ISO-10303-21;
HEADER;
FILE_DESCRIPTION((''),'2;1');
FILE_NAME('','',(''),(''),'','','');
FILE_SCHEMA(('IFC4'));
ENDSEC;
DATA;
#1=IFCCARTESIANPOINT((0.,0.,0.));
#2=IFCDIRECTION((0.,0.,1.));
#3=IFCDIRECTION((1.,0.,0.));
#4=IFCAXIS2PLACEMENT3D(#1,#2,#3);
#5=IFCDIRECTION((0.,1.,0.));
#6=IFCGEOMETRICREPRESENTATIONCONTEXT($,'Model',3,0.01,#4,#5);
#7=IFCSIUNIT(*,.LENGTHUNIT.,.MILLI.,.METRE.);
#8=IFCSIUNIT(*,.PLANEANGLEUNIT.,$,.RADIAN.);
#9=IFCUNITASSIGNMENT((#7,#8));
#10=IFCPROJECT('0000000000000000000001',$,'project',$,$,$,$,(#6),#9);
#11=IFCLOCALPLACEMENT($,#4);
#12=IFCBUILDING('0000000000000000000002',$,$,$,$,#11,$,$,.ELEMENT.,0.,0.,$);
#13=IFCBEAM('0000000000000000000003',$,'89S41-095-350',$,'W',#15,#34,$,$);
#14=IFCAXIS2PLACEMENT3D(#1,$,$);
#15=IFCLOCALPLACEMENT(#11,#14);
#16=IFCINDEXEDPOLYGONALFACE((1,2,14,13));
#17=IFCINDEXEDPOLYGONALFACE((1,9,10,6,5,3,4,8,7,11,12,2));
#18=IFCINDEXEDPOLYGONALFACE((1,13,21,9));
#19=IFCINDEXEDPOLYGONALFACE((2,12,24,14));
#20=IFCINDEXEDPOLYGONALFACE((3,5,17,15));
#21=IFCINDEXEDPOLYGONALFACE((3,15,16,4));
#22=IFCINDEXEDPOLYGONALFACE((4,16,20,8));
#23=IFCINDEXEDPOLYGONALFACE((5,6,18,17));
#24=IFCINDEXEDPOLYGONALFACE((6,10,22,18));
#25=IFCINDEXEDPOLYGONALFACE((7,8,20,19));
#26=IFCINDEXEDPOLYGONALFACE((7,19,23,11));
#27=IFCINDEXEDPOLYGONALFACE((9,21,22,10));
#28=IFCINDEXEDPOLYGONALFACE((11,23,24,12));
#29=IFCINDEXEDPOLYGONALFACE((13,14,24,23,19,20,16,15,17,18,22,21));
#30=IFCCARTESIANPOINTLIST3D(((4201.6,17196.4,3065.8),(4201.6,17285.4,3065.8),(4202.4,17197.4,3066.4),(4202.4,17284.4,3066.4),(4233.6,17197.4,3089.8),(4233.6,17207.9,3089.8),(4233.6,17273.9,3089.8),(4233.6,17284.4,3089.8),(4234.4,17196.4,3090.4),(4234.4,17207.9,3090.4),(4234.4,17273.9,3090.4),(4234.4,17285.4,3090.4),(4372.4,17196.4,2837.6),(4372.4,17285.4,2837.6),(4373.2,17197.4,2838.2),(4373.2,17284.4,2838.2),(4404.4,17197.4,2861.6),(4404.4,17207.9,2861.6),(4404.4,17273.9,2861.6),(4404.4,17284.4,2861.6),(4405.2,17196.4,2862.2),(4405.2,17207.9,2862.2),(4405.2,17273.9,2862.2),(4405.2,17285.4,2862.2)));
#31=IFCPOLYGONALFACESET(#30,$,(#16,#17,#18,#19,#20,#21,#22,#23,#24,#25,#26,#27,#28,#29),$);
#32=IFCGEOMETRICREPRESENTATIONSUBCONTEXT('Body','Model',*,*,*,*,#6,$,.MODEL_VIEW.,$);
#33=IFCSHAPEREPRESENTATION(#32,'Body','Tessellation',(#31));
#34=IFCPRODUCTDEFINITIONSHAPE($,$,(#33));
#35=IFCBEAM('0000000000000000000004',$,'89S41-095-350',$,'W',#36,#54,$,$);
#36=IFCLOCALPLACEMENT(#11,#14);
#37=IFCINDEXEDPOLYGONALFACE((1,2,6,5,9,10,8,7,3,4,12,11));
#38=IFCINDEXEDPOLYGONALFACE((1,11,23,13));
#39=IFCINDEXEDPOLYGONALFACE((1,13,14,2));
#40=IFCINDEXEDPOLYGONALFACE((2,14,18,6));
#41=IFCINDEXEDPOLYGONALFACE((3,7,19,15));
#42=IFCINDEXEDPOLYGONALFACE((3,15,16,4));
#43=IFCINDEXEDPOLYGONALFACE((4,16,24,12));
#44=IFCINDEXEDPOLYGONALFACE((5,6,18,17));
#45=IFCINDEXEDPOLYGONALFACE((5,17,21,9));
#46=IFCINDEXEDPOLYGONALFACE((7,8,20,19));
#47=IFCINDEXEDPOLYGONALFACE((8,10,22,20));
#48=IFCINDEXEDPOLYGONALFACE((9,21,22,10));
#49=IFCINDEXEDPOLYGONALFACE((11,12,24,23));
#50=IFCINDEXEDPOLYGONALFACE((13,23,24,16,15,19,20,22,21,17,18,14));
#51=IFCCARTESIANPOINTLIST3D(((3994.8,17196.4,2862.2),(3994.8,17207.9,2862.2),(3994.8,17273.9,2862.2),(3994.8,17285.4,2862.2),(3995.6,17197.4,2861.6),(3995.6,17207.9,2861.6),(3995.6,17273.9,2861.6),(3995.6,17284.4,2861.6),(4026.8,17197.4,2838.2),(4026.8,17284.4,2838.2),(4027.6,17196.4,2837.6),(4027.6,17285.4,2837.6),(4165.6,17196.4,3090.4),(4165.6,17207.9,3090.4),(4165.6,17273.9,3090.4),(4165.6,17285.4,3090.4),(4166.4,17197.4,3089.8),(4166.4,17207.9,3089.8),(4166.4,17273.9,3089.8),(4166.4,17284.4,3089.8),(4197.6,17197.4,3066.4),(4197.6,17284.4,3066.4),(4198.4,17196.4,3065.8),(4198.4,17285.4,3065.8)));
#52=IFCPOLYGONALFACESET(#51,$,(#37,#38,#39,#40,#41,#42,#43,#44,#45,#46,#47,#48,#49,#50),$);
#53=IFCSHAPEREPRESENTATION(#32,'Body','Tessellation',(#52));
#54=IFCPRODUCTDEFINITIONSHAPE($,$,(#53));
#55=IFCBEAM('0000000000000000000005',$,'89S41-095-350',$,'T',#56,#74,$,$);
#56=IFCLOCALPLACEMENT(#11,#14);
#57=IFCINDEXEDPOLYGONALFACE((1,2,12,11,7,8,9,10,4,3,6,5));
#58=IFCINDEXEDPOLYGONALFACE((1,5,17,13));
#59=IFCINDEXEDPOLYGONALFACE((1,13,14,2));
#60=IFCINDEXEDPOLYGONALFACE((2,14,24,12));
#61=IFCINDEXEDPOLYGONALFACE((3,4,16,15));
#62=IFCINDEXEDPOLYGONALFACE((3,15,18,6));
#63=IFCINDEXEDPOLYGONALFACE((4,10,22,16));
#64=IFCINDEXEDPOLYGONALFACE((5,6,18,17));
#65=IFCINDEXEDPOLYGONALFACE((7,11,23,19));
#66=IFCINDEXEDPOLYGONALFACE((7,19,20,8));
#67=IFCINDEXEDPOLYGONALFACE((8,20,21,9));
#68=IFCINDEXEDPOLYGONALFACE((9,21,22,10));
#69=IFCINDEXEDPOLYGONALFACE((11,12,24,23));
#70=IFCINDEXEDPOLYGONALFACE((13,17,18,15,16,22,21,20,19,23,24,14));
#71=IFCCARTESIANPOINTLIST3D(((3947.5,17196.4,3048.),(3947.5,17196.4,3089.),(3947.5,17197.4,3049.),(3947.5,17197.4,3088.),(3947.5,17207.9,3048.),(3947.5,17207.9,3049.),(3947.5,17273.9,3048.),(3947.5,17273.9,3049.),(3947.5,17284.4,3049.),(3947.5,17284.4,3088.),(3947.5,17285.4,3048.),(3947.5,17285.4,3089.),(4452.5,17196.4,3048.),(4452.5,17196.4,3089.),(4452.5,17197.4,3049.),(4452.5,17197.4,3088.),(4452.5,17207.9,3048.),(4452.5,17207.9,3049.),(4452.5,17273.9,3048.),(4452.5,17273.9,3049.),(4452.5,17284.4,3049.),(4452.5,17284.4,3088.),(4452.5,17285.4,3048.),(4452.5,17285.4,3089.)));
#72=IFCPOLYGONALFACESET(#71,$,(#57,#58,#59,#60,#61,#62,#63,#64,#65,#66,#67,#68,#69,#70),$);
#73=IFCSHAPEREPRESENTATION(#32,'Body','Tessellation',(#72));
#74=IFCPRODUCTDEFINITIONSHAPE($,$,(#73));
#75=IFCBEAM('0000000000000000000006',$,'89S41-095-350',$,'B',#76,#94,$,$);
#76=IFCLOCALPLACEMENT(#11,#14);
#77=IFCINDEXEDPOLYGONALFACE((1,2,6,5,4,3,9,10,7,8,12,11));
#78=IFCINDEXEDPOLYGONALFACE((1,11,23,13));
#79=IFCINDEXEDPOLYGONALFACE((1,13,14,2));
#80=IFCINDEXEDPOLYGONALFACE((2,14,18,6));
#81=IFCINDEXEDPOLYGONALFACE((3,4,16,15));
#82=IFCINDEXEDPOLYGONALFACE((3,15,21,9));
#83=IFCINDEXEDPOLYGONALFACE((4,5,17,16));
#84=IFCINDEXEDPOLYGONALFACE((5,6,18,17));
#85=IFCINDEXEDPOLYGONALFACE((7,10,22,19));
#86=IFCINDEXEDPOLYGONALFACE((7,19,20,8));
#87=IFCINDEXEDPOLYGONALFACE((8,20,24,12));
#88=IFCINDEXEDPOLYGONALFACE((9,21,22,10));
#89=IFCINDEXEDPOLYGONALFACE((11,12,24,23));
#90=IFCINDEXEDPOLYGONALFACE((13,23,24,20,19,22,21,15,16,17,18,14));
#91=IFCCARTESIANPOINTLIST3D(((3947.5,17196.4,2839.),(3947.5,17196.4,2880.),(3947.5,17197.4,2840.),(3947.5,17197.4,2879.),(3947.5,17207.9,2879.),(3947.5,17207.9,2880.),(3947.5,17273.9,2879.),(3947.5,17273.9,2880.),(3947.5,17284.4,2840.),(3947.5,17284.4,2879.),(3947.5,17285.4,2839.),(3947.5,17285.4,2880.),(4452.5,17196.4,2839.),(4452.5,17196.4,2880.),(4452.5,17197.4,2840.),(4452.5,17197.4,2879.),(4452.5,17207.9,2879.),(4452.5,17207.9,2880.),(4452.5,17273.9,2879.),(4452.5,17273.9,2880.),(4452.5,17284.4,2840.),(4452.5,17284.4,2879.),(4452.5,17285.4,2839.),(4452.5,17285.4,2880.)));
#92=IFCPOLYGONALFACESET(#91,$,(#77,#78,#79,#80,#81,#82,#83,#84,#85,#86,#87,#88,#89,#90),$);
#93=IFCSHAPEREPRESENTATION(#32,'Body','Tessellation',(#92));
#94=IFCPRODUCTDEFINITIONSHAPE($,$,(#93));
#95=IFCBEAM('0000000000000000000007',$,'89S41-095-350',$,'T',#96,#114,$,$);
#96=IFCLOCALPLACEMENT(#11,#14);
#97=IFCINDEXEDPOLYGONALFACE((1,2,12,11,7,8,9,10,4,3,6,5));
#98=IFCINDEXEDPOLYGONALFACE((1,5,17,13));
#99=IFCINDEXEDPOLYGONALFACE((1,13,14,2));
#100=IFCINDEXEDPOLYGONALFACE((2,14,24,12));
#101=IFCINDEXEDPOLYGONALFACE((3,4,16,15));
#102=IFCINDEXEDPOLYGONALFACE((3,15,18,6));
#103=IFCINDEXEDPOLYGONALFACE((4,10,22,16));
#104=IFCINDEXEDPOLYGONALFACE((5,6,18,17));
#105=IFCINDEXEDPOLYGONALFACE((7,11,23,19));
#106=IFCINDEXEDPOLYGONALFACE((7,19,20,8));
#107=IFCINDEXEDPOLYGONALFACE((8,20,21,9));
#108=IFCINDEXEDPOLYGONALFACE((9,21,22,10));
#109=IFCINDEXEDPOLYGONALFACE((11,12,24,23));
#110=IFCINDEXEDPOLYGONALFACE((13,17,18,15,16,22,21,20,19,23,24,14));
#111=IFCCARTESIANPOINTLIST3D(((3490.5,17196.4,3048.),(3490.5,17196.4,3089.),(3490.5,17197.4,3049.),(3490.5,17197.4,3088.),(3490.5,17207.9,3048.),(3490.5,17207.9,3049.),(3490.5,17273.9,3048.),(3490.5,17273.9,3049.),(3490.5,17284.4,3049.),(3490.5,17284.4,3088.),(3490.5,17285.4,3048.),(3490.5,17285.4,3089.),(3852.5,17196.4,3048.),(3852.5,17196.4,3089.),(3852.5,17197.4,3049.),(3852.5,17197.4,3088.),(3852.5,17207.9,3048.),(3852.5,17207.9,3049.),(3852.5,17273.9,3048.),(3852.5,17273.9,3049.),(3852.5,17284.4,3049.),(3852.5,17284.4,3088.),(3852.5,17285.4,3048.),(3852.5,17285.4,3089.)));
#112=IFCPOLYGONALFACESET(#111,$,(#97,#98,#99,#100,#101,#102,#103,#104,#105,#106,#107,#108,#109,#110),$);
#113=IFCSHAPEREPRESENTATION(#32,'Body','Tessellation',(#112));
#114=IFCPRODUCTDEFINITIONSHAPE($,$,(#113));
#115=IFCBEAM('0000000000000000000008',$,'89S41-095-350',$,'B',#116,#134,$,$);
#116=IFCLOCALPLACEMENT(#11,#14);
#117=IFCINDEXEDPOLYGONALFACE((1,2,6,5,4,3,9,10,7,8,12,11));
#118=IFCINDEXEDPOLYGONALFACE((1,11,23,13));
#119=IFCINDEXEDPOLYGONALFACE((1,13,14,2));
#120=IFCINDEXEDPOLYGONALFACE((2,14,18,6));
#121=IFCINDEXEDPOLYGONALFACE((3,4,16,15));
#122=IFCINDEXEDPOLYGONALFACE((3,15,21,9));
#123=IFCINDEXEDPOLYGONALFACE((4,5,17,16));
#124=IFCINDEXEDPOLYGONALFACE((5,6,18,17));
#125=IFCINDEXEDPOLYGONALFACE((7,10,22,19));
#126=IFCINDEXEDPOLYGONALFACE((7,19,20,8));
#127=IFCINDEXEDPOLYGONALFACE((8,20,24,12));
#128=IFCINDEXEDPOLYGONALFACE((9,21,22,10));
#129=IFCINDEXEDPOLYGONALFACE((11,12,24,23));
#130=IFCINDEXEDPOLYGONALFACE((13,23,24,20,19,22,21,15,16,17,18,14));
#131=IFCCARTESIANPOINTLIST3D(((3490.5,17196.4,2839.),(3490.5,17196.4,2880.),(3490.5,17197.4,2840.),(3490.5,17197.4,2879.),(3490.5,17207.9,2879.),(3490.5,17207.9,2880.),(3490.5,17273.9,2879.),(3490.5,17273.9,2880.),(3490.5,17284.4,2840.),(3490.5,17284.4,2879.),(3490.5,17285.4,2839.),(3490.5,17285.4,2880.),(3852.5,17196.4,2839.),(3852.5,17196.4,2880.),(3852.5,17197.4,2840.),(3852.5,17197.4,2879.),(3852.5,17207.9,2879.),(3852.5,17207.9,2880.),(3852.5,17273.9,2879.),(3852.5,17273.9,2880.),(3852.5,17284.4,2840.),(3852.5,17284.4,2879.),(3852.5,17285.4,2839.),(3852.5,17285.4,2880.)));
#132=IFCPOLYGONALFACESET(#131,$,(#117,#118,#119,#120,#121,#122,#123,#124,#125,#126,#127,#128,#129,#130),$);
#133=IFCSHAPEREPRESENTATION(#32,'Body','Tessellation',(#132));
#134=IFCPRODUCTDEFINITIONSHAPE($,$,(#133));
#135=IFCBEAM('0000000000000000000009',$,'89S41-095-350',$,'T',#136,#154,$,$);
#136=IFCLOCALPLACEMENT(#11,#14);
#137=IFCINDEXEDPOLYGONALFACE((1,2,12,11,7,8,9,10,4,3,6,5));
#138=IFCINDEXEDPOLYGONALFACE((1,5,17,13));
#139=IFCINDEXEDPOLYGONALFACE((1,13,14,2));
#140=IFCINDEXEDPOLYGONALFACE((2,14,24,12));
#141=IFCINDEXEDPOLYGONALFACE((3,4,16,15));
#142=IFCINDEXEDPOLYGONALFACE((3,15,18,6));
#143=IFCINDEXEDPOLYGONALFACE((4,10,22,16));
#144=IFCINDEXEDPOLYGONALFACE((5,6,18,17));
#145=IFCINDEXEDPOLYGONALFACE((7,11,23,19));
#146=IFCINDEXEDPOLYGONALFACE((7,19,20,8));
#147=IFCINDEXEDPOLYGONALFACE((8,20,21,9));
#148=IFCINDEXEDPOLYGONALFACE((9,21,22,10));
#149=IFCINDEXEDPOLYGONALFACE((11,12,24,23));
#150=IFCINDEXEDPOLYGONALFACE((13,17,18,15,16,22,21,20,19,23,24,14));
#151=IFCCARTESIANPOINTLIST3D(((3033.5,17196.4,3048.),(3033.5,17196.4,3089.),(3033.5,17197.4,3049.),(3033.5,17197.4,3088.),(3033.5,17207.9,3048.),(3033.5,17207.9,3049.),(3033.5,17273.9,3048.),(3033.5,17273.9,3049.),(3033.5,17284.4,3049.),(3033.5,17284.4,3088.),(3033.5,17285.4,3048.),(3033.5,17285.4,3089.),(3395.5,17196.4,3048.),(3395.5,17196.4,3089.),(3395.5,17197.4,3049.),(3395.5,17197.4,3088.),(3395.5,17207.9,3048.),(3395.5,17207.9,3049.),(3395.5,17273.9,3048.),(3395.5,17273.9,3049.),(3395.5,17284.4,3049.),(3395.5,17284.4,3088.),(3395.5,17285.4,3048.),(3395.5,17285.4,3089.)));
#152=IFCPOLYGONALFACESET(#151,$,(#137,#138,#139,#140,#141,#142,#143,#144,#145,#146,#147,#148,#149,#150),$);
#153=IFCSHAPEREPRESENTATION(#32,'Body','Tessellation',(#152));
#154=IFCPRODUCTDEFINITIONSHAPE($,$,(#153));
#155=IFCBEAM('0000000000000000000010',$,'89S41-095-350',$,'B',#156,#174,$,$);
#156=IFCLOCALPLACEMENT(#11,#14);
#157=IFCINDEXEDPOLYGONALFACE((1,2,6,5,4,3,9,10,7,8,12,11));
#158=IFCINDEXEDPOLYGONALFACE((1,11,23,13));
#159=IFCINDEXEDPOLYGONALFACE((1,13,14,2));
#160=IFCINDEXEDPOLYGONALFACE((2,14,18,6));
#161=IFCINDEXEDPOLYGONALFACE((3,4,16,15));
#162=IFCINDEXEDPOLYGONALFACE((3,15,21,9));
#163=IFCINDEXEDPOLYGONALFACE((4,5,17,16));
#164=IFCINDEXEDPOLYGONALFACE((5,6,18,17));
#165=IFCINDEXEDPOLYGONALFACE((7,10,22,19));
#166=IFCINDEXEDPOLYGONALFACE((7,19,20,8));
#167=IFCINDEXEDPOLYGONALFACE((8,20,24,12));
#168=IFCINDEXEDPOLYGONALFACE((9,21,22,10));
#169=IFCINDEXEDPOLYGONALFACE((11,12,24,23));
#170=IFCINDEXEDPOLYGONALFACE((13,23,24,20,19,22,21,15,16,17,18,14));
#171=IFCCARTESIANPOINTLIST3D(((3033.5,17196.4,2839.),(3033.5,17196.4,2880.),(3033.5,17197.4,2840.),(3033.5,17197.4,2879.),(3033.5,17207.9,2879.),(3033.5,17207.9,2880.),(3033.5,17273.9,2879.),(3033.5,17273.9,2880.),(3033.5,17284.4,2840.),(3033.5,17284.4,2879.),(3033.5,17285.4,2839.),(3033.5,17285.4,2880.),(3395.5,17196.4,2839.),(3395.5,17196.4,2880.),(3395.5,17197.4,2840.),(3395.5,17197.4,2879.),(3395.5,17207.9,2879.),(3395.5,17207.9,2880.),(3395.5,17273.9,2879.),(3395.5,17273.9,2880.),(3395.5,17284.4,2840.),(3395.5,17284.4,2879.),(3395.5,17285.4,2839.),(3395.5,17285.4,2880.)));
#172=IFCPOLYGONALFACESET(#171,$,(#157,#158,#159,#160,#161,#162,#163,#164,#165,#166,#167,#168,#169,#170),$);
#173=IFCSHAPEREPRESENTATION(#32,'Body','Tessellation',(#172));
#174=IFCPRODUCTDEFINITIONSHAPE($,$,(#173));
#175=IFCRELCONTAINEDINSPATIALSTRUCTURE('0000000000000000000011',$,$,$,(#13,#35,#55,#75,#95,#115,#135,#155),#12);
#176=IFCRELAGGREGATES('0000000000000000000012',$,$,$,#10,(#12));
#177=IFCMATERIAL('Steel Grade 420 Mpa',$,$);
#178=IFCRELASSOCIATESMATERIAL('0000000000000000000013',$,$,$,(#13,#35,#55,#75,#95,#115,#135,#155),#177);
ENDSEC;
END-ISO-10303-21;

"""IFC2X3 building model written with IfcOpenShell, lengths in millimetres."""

from ifc_helpers import new_model, si_unit, direction, frame, origin, origin_with_axes, origin_2d_with_axis, place, context, subcontext, project, spatial, c_section, extrude, source, transform, mapped, material, element, save


model = new_model("IFC2X3")

# Units and contexts
model_context = context("Model", 3, precision=0.01, world=origin_with_axes(), true_north=direction((0.0, 1.0, 0.0)))
body_context = subcontext(model_context, "Body", "Model", "MODEL_VIEW")
ifc_project = project(units=[si_unit("LENGTHUNIT", "METRE", prefix="MILLI"), si_unit("PLANEANGLEUNIT", "RADIAN")], contexts=[model_context])

# Building
building_placement = place(None, origin_with_axes())
building = spatial("IfcBuilding", under=ifc_project, at=building_placement, CompositionType="ELEMENT", ElevationOfRefHeight=0.0, ElevationOfTerrain=0.0)

# Shared definitions
ifc_material = material(Name="Steel Grade 420 Mpa")

# Beams
shared_shape_1 = source(origin(), body_context, "Body", "SweptSolid", [
    extrude(c_section(Depth=89.0, Width=41.0, WallThickness=1.0, Girth=11.5, at=origin_2d_with_axis()), origin_with_axes(), (0.0, 0.0, 1.0), 285.1),
])
beam_1_placement = place(None, frame((4218.0, 17240.9, 3078.1), z_axis=(0.599182, 0.0, -0.800613), x_axis=(0.800613, 0.0, 0.599182)))
element("IfcBeam", 1, at=beam_1_placement, inside=building, material=ifc_material, Name="89S41-095-350", ObjectType="W", context=body_context, shape_type="MappedRepresentation", body=[
    mapped(shared_shape_1, transform((0.0, 0.0, 0.0), scale=1.0)),
])
shared_shape_2 = source(origin(), body_context, "Body", "SweptSolid", [
    extrude(c_section(Depth=89.0, Width=41.0, WallThickness=1.0, Girth=11.5, at=origin_2d_with_axis()), origin_with_axes(), (0.0, 0.0, 1.0), 285.1),
])
beam_2_placement = place(None, frame((4011.2, 17240.9, 2849.9), z_axis=(0.599182, 0.0, 0.800613), x_axis=(-0.800613, 0.0, 0.599182)))
element("IfcBeam", 2, at=beam_2_placement, inside=building, material=ifc_material, Name="89S41-095-350", ObjectType="W", context=body_context, shape_type="MappedRepresentation", body=[
    mapped(shared_shape_2, transform((0.0, 0.0, 0.0), scale=1.0)),
])
shared_shape_3 = source(origin(), body_context, "Body", "SweptSolid", [
    extrude(c_section(Depth=89.0, Width=41.0, WallThickness=1.0, Girth=11.5, at=origin_2d_with_axis()), origin_with_axes(), (0.0, 0.0, 1.0), 505.0),
])
beam_3_placement = place(None, frame((4452.5, 17240.9, 3068.5), z_axis=(-1.0, 0.0, 0.0), x_axis=(0.0, 0.0, -1.0)))
element("IfcBeam", 3, at=beam_3_placement, inside=building, material=ifc_material, Name="89S41-095-350", ObjectType="T", context=body_context, shape_type="MappedRepresentation", body=[
    mapped(shared_shape_3, transform((0.0, 0.0, 0.0), scale=1.0)),
])
shared_shape_4 = source(origin(), body_context, "Body", "SweptSolid", [
    extrude(c_section(Depth=89.0, Width=41.0, WallThickness=1.0, Girth=11.5, at=origin_2d_with_axis()), origin_with_axes(), (0.0, 0.0, 1.0), 505.0),
])
beam_4_placement = place(None, frame((3947.5, 17240.9, 2859.5), z_axis=(1.0, 0.0, 0.0), x_axis=(0.0, 0.0, 1.0)))
element("IfcBeam", 4, at=beam_4_placement, inside=building, material=ifc_material, Name="89S41-095-350", ObjectType="B", context=body_context, shape_type="MappedRepresentation", body=[
    mapped(shared_shape_4, transform((0.0, 0.0, 0.0), scale=1.0)),
])
shared_shape_5 = source(origin(), body_context, "Body", "SweptSolid", [
    extrude(c_section(Depth=89.0, Width=41.0, WallThickness=1.0, Girth=11.5, at=origin_2d_with_axis()), origin_with_axes(), (0.0, 0.0, 1.0), 362.0),
])
beam_5_placement = place(None, frame((3852.5, 17240.9, 3068.5), z_axis=(-1.0, 0.0, 0.0), x_axis=(0.0, 0.0, -1.0)))
element("IfcBeam", 5, at=beam_5_placement, inside=building, material=ifc_material, Name="89S41-095-350", ObjectType="T", context=body_context, shape_type="MappedRepresentation", body=[
    mapped(shared_shape_5, transform((0.0, 0.0, 0.0), scale=1.0)),
])
shared_shape_6 = source(origin(), body_context, "Body", "SweptSolid", [
    extrude(c_section(Depth=89.0, Width=41.0, WallThickness=1.0, Girth=11.5, at=origin_2d_with_axis()), origin_with_axes(), (0.0, 0.0, 1.0), 362.0),
])
beam_6_placement = place(None, frame((3490.5, 17240.9, 2859.5), z_axis=(1.0, 0.0, 0.0), x_axis=(0.0, 0.0, 1.0)))
element("IfcBeam", 6, at=beam_6_placement, inside=building, material=ifc_material, Name="89S41-095-350", ObjectType="B", context=body_context, shape_type="MappedRepresentation", body=[
    mapped(shared_shape_6, transform((0.0, 0.0, 0.0), scale=1.0)),
])
shared_shape_7 = source(origin(), body_context, "Body", "SweptSolid", [
    extrude(c_section(Depth=89.0, Width=41.0, WallThickness=1.0, Girth=11.5, at=origin_2d_with_axis()), origin_with_axes(), (0.0, 0.0, 1.0), 362.0),
])
beam_7_placement = place(None, frame((3395.5, 17240.9, 3068.5), z_axis=(-1.0, 0.0, 0.0), x_axis=(0.0, 0.0, -1.0)))
element("IfcBeam", 7, at=beam_7_placement, inside=building, material=ifc_material, Name="89S41-095-350", ObjectType="T", context=body_context, shape_type="MappedRepresentation", body=[
    mapped(shared_shape_7, transform((0.0, 0.0, 0.0), scale=1.0)),
])
shared_shape_8 = source(origin(), body_context, "Body", "SweptSolid", [
    extrude(c_section(Depth=89.0, Width=41.0, WallThickness=1.0, Girth=11.5, at=origin_2d_with_axis()), origin_with_axes(), (0.0, 0.0, 1.0), 362.0),
])
beam_8_placement = place(None, frame((3033.5, 17240.9, 2859.5), z_axis=(1.0, 0.0, 0.0), x_axis=(0.0, 0.0, 1.0)))
element("IfcBeam", 8, at=beam_8_placement, inside=building, material=ifc_material, Name="89S41-095-350", ObjectType="B", context=body_context, shape_type="MappedRepresentation", body=[
    mapped(shared_shape_8, transform((0.0, 0.0, 0.0), scale=1.0)),
])

save(model, "model.ifc")
